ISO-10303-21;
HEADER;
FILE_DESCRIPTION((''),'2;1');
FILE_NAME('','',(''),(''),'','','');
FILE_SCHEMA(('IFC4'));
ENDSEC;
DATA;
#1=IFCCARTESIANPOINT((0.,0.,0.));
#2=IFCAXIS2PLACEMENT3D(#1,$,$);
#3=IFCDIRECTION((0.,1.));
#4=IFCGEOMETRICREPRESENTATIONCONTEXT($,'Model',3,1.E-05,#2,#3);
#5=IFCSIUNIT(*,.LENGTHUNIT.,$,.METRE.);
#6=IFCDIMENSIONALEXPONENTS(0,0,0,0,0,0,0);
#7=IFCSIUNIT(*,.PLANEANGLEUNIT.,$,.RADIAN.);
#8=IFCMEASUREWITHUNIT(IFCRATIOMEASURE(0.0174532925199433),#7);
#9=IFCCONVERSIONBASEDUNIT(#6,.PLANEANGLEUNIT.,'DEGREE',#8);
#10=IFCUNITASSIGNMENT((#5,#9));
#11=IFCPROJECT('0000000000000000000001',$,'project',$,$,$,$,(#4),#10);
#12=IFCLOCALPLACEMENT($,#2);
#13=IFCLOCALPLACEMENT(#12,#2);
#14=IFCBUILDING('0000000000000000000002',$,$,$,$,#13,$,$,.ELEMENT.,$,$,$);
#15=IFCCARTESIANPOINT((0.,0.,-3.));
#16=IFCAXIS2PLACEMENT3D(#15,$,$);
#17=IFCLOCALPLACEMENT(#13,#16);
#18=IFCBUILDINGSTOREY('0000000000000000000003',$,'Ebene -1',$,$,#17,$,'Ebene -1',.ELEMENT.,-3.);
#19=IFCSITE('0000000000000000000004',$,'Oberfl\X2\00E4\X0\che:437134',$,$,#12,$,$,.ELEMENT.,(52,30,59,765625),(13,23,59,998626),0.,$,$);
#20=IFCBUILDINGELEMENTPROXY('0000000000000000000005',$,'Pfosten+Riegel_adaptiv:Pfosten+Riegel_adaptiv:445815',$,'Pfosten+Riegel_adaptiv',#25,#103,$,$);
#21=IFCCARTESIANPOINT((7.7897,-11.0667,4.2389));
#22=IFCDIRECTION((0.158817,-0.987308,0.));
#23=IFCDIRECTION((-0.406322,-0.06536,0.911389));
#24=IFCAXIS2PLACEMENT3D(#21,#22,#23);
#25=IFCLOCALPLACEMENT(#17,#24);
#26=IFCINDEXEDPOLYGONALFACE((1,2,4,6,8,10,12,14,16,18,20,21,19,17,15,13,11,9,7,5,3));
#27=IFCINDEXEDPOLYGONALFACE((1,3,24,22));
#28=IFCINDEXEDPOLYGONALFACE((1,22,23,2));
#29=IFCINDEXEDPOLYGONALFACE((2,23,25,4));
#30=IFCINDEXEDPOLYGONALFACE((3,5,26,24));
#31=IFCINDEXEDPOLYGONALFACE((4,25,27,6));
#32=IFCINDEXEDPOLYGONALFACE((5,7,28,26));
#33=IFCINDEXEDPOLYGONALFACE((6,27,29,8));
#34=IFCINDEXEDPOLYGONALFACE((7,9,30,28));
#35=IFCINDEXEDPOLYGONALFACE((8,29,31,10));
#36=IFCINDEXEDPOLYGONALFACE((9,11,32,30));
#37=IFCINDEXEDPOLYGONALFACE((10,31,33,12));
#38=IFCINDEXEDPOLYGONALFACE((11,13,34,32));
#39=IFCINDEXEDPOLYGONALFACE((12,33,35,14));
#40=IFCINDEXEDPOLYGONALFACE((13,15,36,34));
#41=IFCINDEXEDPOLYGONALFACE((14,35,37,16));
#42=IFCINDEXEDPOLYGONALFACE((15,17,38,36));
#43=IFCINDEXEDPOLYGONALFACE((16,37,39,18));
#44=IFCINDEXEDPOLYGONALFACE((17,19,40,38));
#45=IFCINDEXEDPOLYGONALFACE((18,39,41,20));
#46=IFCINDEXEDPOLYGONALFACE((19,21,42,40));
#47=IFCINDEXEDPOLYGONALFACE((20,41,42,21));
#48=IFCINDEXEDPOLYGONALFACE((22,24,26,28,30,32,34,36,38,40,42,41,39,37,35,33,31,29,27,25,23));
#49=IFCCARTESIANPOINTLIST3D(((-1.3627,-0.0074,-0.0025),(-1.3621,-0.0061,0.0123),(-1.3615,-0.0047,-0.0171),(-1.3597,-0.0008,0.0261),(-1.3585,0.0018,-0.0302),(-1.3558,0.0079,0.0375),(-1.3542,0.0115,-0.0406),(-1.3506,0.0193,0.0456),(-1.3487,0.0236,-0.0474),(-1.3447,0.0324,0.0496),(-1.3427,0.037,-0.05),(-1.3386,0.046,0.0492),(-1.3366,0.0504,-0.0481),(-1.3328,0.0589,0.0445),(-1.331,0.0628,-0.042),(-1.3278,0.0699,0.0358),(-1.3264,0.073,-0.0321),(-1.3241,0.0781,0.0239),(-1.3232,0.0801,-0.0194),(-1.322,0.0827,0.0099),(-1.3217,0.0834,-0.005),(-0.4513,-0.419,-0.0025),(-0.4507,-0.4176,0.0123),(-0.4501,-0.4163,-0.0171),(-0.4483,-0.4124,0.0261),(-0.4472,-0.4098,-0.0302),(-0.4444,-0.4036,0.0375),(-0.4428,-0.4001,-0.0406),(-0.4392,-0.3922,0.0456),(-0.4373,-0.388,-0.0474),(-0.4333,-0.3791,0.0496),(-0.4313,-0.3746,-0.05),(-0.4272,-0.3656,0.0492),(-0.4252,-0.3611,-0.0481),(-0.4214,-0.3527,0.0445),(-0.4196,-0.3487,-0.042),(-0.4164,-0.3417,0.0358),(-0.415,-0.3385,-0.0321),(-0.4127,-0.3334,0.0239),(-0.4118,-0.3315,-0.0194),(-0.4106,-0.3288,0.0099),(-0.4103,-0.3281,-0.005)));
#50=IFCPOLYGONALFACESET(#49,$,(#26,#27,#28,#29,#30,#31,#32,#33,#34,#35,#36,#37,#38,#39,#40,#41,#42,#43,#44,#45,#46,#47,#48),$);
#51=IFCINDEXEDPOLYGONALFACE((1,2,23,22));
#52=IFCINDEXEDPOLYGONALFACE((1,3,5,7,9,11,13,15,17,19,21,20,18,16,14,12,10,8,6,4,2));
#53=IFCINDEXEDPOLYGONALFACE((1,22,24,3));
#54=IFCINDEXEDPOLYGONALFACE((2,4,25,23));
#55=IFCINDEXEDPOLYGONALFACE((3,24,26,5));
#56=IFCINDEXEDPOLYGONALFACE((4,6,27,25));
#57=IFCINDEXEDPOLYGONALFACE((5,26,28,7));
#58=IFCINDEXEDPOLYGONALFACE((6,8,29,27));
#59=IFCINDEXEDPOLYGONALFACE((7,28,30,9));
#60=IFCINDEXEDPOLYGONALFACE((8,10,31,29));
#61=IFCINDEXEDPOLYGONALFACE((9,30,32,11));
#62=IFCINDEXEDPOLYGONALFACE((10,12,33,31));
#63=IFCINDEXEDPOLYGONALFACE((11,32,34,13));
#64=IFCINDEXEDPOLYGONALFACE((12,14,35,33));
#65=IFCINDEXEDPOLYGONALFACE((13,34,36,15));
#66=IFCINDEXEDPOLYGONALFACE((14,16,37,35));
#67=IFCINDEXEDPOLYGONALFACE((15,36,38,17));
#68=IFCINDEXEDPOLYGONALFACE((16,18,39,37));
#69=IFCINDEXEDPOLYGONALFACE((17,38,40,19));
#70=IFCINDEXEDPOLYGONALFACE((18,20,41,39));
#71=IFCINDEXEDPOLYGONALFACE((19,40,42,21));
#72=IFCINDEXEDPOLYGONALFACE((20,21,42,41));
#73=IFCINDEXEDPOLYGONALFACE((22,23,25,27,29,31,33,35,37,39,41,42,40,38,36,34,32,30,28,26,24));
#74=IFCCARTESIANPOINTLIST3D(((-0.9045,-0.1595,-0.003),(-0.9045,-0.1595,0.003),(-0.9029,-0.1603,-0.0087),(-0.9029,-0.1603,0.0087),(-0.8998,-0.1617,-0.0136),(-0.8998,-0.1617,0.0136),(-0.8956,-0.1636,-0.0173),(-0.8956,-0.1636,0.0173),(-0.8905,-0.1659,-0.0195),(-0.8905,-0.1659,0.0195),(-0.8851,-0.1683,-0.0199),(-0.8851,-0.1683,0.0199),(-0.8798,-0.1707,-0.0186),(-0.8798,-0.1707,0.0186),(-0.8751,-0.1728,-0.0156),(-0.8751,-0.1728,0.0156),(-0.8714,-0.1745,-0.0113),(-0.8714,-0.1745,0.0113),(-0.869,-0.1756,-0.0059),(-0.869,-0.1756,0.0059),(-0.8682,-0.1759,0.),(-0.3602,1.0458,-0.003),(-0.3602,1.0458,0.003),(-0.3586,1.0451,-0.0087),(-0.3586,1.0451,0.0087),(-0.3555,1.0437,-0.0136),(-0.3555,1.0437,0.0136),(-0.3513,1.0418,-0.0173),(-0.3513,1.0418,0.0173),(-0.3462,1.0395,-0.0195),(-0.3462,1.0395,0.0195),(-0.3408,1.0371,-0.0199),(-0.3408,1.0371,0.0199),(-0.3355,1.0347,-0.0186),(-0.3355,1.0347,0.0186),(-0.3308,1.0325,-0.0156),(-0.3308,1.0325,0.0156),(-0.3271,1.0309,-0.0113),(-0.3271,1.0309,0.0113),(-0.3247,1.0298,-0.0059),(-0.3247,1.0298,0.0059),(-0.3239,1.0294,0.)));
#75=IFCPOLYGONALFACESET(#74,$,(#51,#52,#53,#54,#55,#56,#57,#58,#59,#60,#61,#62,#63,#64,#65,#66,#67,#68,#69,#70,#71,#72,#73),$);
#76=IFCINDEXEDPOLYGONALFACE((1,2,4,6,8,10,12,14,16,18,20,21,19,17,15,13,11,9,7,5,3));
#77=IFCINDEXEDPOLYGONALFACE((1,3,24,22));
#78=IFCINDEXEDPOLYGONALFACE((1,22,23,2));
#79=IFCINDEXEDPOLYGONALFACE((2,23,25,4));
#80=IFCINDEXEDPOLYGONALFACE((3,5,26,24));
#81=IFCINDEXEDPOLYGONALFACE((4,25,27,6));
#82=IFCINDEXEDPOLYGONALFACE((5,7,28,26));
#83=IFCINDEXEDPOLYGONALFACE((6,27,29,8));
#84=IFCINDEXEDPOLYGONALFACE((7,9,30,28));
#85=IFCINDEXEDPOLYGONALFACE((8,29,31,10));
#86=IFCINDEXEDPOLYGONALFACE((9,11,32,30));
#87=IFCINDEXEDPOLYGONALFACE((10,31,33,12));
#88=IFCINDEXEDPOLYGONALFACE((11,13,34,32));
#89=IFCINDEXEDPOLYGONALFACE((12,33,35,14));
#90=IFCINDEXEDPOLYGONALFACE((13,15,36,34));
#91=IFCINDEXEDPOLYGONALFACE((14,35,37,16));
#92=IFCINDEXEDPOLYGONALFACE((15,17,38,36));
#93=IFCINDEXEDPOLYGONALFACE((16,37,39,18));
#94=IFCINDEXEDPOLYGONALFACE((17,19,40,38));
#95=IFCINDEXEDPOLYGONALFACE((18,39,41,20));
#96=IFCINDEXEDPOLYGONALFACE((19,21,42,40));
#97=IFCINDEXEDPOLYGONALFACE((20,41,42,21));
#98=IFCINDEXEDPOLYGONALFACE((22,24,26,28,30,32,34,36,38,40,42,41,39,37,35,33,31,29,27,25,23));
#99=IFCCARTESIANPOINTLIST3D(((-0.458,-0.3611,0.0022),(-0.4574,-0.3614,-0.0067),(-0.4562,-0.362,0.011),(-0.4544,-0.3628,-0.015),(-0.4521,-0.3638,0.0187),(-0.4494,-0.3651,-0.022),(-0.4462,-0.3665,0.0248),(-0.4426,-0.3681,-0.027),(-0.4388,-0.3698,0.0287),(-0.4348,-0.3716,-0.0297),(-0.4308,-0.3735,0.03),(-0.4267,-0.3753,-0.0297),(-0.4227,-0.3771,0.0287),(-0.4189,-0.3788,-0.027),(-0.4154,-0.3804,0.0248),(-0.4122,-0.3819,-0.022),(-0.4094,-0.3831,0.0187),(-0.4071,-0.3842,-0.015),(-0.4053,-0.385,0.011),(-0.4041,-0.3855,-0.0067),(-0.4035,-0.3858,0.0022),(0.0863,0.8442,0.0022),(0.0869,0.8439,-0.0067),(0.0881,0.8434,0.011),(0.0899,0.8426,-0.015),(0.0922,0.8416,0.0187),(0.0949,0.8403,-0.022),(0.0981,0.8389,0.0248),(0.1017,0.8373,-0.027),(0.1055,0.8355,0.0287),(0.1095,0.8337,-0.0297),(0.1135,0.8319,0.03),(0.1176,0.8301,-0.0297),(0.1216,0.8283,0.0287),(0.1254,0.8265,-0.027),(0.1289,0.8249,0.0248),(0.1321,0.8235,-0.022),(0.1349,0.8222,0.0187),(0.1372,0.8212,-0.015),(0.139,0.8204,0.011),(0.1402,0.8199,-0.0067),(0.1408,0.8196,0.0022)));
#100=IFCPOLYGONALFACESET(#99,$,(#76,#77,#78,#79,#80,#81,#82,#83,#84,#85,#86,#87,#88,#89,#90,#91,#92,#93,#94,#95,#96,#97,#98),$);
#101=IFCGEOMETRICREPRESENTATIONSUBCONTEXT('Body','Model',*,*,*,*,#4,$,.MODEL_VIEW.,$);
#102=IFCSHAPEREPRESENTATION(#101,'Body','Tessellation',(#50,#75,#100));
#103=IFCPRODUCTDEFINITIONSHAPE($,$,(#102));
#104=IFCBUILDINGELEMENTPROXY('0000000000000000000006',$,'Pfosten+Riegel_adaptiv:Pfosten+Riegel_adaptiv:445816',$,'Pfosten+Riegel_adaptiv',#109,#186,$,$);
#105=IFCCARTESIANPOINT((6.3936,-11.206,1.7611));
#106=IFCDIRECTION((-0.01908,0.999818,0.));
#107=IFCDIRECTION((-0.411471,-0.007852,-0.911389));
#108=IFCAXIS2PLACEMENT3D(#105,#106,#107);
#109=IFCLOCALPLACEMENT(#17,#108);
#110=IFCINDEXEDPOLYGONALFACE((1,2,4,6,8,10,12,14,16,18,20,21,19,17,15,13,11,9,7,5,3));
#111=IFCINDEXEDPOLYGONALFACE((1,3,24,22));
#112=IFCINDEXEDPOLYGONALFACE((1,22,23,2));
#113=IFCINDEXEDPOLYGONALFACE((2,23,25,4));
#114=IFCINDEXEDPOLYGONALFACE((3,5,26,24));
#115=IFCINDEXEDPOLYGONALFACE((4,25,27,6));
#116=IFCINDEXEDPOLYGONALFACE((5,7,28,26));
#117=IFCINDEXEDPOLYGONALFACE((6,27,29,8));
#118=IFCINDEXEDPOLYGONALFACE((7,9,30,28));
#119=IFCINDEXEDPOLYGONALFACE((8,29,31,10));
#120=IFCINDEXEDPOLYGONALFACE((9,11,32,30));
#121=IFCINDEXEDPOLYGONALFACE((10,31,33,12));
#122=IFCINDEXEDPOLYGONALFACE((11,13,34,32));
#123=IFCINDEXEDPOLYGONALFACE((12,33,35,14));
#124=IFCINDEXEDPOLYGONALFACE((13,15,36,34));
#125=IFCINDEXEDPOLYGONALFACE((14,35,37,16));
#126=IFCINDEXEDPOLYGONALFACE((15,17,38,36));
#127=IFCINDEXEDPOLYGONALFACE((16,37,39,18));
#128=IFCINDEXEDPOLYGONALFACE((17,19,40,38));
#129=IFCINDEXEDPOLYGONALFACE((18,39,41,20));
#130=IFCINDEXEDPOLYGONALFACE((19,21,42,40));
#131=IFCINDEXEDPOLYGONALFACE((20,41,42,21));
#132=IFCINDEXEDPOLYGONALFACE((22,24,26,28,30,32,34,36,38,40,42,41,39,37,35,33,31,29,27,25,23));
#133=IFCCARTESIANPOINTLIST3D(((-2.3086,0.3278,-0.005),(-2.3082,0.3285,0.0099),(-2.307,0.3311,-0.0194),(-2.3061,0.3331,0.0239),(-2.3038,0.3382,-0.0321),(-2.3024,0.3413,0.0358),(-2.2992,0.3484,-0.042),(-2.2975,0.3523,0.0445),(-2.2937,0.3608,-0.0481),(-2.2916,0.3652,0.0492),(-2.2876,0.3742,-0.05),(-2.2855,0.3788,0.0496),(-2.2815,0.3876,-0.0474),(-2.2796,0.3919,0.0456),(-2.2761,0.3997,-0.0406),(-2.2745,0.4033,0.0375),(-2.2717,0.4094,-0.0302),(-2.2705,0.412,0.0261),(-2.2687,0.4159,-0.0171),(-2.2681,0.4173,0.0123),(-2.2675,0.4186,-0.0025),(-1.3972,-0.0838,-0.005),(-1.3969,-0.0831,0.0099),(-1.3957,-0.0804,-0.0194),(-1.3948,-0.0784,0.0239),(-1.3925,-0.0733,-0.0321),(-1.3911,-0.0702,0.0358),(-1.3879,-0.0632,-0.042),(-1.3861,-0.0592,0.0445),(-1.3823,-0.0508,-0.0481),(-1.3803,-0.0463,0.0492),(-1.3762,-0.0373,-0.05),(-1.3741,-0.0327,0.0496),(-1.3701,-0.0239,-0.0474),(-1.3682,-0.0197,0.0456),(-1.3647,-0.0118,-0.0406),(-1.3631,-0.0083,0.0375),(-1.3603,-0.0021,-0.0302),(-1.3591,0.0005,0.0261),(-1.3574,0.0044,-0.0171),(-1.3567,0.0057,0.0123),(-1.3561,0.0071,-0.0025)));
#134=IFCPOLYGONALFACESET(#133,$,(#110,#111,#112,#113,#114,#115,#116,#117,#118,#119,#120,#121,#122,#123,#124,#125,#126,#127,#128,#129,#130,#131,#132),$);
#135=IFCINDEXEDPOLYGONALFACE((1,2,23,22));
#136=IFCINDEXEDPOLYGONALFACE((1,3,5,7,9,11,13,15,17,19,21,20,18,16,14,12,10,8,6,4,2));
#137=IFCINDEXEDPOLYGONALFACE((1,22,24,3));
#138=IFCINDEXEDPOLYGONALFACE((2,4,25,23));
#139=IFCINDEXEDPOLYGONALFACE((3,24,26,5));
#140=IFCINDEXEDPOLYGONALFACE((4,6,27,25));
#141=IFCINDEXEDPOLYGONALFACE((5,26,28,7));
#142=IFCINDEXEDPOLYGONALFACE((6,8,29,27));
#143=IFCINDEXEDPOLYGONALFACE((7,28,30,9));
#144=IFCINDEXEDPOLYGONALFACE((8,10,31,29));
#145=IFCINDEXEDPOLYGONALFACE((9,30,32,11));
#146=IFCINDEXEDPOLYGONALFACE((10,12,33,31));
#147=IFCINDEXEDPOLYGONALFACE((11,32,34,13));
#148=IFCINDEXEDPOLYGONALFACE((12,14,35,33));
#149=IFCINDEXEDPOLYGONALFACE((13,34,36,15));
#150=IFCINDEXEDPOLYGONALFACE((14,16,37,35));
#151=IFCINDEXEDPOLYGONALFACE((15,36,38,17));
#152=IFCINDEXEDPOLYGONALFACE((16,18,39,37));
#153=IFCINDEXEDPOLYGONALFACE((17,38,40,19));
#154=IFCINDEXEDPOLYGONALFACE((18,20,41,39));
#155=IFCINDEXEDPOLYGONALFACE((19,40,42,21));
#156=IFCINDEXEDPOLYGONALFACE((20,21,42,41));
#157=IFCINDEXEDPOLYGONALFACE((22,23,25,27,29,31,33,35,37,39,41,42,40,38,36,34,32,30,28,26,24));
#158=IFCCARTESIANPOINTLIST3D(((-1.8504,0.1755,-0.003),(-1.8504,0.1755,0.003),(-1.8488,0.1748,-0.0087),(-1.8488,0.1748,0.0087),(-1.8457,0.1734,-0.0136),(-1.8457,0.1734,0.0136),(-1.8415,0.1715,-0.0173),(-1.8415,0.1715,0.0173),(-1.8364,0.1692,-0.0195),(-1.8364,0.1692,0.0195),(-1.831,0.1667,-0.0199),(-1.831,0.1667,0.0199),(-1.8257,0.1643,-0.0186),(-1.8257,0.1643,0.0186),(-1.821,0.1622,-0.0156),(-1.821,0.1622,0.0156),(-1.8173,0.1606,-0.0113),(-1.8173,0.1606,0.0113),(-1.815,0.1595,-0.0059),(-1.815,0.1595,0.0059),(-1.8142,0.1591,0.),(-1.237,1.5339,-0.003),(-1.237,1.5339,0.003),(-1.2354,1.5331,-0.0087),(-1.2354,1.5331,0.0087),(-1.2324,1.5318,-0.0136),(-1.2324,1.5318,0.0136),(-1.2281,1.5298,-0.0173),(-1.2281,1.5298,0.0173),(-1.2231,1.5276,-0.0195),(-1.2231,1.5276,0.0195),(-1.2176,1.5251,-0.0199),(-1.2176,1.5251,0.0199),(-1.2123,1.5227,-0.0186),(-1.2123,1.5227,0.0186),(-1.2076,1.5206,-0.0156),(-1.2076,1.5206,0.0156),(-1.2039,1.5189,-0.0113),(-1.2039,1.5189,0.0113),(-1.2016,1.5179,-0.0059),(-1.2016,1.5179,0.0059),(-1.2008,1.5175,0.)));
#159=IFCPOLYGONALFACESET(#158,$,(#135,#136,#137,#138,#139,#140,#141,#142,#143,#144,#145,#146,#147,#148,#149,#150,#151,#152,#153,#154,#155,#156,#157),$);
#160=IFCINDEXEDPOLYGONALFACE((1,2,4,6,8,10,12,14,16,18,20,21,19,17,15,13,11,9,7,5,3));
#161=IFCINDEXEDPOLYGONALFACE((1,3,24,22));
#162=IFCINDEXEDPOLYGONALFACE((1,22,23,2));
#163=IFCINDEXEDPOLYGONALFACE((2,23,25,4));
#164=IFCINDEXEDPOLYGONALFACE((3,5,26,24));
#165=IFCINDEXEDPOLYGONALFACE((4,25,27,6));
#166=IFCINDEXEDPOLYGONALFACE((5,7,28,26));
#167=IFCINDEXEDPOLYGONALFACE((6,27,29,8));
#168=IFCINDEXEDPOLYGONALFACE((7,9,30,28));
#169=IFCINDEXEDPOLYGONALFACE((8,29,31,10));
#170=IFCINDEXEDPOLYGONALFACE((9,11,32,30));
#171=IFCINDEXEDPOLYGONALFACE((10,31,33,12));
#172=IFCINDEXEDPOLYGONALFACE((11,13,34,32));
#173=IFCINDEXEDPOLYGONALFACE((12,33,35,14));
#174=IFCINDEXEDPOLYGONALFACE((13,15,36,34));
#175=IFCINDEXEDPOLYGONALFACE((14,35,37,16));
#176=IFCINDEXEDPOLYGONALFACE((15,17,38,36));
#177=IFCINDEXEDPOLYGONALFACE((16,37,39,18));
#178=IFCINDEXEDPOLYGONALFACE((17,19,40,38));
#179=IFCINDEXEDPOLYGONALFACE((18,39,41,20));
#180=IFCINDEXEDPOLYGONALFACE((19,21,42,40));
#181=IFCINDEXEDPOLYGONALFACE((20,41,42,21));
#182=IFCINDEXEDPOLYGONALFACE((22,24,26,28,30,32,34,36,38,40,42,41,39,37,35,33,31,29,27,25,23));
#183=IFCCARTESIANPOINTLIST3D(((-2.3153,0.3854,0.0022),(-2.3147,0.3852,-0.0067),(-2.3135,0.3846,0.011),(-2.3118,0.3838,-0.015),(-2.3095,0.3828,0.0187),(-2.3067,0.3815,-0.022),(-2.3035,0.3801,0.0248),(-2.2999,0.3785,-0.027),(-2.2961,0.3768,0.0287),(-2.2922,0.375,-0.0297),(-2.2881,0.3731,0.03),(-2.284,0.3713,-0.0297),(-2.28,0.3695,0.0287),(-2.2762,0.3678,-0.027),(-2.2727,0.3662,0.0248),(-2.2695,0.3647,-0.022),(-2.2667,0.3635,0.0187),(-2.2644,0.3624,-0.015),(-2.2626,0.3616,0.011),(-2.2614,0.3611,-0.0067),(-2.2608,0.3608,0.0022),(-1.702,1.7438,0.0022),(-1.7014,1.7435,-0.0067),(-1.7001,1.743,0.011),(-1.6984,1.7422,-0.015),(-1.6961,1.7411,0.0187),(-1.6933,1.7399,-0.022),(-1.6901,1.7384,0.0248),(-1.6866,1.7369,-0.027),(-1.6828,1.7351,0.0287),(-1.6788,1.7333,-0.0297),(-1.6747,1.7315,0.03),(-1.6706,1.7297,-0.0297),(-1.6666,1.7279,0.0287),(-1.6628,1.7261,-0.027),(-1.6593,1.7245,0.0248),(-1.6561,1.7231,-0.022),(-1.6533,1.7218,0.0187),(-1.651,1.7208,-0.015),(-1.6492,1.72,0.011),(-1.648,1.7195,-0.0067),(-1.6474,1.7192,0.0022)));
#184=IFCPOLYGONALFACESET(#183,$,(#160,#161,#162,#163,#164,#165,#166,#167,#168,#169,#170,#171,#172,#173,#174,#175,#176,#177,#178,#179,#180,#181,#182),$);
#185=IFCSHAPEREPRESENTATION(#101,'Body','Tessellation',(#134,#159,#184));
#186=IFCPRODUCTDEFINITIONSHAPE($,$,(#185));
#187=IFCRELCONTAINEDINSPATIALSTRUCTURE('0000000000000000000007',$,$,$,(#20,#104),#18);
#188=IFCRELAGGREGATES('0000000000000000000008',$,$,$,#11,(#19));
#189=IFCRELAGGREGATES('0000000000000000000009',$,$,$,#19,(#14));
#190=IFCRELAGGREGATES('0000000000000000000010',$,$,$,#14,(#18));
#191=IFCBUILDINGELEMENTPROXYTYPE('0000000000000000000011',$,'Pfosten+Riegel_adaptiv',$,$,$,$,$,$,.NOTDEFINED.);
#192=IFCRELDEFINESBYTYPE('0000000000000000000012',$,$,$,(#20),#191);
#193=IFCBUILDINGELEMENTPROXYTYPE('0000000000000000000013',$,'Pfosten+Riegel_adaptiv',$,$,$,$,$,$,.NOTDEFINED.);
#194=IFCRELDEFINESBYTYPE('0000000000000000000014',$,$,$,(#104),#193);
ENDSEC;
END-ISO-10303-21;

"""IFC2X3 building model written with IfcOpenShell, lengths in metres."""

from ifc_helpers import new_model, entity, si_unit, converted_unit, direction, frame, frame_2d, origin, place, context, subcontext, project, spatial, circle, extrude, source, transform, mapped, type_object, type_shapes, element, save


model = new_model("IFC2X3")

# Units and contexts
model_context = context("Model", 3, precision=1e-05, world=origin(), true_north=direction((0.0, 1.0)))
body_context = subcontext(model_context, "Body", "Model", "MODEL_VIEW")
ifc_project = project(units=[si_unit("LENGTHUNIT", "METRE"), converted_unit("PLANEANGLEUNIT", "DEGREE", entity("IfcRatioMeasure", 0.0174532925199433), si_unit("PLANEANGLEUNIT", "RADIAN"), dimensions=[0, 0, 0, 0, 0, 0, 0])], contexts=[model_context])

# Site, building, storey
site_placement = place(None, origin())
site = spatial("IfcSite", under=ifc_project, at=site_placement, Name="Oberfläche:437134", CompositionType="ELEMENT", RefLatitude=(52, 30, 59, 765625), RefLongitude=(13, 23, 59, 998626), RefElevation=0.0)
building_placement = place(site_placement, origin())
building = spatial("IfcBuilding", under=site, at=building_placement, CompositionType="ELEMENT")
storey_placement = place(building_placement, frame((0.0, 0.0, -3.0)))
storey = spatial("IfcBuildingStorey", under=building, at=storey_placement, Name="Ebene -1", LongName="Ebene -1", CompositionType="ELEMENT", Elevation=-3.0)

# Building element proxies
building_element_proxy_type_1 = type_object("IfcBuildingElementProxyType", Name="Pfosten+Riegel_adaptiv", PredefinedType="NOTDEFINED")
shared_shape_1 = source(origin(), body_context, "Body", "SweptSolid", [
    extrude(circle(Radius=0.05, at=frame_2d((0.0, 0.0), x_axis=(1.0, 0.0))), frame((-1.3421, 0.0381, 0.0), z_axis=(0.911389, -0.411546, 0.0), x_axis=(-0.16937, -0.375078, 0.911389)), (0.0, 0.0, 1.0), 1.0),
    extrude(circle(Radius=0.02, at=frame_2d((0.0, 0.0), x_axis=(1.0, 0.0))), frame((-0.8865, -0.1677, 0.0), z_axis=(0.411546, 0.911389, 0.0), x_axis=(0.911389, -0.411546, 0.0)), (0.0, 0.0, 1.0), 1.3226),
    extrude(circle(Radius=0.03, at=frame_2d((0.0, 0.0), x_axis=(1.0, 0.0))), frame((-0.4308, -0.3735, 0.0), z_axis=(0.411546, 0.911389, 0.0), x_axis=(0.0, 0.0, 1.0)), (0.0, 0.0, 1.0), 1.3226),
])
type_shapes(building_element_proxy_type_1, [shared_shape_1])
proxy_1_placement = place(storey_placement, frame((7.7897, -11.0667, 4.2389), z_axis=(0.158817, -0.987308, 0.0), x_axis=(-0.406322, -0.06536, 0.911389)))
element("IfcBuildingElementProxy", 1, at=proxy_1_placement, inside=storey, type_object=building_element_proxy_type_1, Name="Pfosten+Riegel_adaptiv:Pfosten+Riegel_adaptiv:445815", ObjectType="Pfosten+Riegel_adaptiv", context=body_context, shape_type="MappedRepresentation", body=[
    mapped(shared_shape_1, transform((0.0, 0.0, 0.0), scale=1.0)),
])
building_element_proxy_type_2 = type_object("IfcBuildingElementProxyType", Name="Pfosten+Riegel_adaptiv", PredefinedType="NOTDEFINED")
shared_shape_2 = source(origin(), body_context, "Body", "SweptSolid", [
    extrude(circle(Radius=0.05, at=frame_2d((0.0, 0.0), x_axis=(1.0, 0.0))), frame((-2.2881, 0.3731, 0.0), z_axis=(0.911389, -0.411546, 0.0), x_axis=(0.16937, 0.375078, 0.911389)), (0.0, 0.0, 1.0), 1.0),
    extrude(circle(Radius=0.02, at=frame_2d((0.0, 0.0), x_axis=(1.0, 0.0))), frame((-1.8324, 0.1674, 0.0), z_axis=(0.411546, 0.911389, 0.0), x_axis=(0.911389, -0.411546, 0.0)), (0.0, 0.0, 1.0), 1.4904),
    extrude(circle(Radius=0.03, at=frame_2d((0.0, 0.0), x_axis=(1.0, 0.0))), frame((-2.2881, 0.3731, 0.0), z_axis=(0.411546, 0.911389, 0.0), x_axis=(0.0, 0.0, 1.0)), (0.0, 0.0, 1.0), 1.4904),
])
type_shapes(building_element_proxy_type_2, [shared_shape_2])
for number, where, z_axis, x_axis, name in (
    (2, (6.3936, -11.206, 1.7611), (-0.01908, 0.999818, 0.0), (-0.411471, -0.007852, -0.911389), "Pfosten+Riegel_adaptiv:Pfosten+Riegel_adaptiv:445816"),
):
    element("IfcBuildingElementProxy", number, at=place(storey_placement, frame(where, z_axis=z_axis, x_axis=x_axis)), inside=storey, type_object=building_element_proxy_type_2, Name=name, ObjectType="Pfosten+Riegel_adaptiv", context=body_context, shape_type="MappedRepresentation", body=[
        mapped(shared_shape_2, transform((0.0, 0.0, 0.0), scale=1.0)),
    ])

save(model, "model.ifc")
